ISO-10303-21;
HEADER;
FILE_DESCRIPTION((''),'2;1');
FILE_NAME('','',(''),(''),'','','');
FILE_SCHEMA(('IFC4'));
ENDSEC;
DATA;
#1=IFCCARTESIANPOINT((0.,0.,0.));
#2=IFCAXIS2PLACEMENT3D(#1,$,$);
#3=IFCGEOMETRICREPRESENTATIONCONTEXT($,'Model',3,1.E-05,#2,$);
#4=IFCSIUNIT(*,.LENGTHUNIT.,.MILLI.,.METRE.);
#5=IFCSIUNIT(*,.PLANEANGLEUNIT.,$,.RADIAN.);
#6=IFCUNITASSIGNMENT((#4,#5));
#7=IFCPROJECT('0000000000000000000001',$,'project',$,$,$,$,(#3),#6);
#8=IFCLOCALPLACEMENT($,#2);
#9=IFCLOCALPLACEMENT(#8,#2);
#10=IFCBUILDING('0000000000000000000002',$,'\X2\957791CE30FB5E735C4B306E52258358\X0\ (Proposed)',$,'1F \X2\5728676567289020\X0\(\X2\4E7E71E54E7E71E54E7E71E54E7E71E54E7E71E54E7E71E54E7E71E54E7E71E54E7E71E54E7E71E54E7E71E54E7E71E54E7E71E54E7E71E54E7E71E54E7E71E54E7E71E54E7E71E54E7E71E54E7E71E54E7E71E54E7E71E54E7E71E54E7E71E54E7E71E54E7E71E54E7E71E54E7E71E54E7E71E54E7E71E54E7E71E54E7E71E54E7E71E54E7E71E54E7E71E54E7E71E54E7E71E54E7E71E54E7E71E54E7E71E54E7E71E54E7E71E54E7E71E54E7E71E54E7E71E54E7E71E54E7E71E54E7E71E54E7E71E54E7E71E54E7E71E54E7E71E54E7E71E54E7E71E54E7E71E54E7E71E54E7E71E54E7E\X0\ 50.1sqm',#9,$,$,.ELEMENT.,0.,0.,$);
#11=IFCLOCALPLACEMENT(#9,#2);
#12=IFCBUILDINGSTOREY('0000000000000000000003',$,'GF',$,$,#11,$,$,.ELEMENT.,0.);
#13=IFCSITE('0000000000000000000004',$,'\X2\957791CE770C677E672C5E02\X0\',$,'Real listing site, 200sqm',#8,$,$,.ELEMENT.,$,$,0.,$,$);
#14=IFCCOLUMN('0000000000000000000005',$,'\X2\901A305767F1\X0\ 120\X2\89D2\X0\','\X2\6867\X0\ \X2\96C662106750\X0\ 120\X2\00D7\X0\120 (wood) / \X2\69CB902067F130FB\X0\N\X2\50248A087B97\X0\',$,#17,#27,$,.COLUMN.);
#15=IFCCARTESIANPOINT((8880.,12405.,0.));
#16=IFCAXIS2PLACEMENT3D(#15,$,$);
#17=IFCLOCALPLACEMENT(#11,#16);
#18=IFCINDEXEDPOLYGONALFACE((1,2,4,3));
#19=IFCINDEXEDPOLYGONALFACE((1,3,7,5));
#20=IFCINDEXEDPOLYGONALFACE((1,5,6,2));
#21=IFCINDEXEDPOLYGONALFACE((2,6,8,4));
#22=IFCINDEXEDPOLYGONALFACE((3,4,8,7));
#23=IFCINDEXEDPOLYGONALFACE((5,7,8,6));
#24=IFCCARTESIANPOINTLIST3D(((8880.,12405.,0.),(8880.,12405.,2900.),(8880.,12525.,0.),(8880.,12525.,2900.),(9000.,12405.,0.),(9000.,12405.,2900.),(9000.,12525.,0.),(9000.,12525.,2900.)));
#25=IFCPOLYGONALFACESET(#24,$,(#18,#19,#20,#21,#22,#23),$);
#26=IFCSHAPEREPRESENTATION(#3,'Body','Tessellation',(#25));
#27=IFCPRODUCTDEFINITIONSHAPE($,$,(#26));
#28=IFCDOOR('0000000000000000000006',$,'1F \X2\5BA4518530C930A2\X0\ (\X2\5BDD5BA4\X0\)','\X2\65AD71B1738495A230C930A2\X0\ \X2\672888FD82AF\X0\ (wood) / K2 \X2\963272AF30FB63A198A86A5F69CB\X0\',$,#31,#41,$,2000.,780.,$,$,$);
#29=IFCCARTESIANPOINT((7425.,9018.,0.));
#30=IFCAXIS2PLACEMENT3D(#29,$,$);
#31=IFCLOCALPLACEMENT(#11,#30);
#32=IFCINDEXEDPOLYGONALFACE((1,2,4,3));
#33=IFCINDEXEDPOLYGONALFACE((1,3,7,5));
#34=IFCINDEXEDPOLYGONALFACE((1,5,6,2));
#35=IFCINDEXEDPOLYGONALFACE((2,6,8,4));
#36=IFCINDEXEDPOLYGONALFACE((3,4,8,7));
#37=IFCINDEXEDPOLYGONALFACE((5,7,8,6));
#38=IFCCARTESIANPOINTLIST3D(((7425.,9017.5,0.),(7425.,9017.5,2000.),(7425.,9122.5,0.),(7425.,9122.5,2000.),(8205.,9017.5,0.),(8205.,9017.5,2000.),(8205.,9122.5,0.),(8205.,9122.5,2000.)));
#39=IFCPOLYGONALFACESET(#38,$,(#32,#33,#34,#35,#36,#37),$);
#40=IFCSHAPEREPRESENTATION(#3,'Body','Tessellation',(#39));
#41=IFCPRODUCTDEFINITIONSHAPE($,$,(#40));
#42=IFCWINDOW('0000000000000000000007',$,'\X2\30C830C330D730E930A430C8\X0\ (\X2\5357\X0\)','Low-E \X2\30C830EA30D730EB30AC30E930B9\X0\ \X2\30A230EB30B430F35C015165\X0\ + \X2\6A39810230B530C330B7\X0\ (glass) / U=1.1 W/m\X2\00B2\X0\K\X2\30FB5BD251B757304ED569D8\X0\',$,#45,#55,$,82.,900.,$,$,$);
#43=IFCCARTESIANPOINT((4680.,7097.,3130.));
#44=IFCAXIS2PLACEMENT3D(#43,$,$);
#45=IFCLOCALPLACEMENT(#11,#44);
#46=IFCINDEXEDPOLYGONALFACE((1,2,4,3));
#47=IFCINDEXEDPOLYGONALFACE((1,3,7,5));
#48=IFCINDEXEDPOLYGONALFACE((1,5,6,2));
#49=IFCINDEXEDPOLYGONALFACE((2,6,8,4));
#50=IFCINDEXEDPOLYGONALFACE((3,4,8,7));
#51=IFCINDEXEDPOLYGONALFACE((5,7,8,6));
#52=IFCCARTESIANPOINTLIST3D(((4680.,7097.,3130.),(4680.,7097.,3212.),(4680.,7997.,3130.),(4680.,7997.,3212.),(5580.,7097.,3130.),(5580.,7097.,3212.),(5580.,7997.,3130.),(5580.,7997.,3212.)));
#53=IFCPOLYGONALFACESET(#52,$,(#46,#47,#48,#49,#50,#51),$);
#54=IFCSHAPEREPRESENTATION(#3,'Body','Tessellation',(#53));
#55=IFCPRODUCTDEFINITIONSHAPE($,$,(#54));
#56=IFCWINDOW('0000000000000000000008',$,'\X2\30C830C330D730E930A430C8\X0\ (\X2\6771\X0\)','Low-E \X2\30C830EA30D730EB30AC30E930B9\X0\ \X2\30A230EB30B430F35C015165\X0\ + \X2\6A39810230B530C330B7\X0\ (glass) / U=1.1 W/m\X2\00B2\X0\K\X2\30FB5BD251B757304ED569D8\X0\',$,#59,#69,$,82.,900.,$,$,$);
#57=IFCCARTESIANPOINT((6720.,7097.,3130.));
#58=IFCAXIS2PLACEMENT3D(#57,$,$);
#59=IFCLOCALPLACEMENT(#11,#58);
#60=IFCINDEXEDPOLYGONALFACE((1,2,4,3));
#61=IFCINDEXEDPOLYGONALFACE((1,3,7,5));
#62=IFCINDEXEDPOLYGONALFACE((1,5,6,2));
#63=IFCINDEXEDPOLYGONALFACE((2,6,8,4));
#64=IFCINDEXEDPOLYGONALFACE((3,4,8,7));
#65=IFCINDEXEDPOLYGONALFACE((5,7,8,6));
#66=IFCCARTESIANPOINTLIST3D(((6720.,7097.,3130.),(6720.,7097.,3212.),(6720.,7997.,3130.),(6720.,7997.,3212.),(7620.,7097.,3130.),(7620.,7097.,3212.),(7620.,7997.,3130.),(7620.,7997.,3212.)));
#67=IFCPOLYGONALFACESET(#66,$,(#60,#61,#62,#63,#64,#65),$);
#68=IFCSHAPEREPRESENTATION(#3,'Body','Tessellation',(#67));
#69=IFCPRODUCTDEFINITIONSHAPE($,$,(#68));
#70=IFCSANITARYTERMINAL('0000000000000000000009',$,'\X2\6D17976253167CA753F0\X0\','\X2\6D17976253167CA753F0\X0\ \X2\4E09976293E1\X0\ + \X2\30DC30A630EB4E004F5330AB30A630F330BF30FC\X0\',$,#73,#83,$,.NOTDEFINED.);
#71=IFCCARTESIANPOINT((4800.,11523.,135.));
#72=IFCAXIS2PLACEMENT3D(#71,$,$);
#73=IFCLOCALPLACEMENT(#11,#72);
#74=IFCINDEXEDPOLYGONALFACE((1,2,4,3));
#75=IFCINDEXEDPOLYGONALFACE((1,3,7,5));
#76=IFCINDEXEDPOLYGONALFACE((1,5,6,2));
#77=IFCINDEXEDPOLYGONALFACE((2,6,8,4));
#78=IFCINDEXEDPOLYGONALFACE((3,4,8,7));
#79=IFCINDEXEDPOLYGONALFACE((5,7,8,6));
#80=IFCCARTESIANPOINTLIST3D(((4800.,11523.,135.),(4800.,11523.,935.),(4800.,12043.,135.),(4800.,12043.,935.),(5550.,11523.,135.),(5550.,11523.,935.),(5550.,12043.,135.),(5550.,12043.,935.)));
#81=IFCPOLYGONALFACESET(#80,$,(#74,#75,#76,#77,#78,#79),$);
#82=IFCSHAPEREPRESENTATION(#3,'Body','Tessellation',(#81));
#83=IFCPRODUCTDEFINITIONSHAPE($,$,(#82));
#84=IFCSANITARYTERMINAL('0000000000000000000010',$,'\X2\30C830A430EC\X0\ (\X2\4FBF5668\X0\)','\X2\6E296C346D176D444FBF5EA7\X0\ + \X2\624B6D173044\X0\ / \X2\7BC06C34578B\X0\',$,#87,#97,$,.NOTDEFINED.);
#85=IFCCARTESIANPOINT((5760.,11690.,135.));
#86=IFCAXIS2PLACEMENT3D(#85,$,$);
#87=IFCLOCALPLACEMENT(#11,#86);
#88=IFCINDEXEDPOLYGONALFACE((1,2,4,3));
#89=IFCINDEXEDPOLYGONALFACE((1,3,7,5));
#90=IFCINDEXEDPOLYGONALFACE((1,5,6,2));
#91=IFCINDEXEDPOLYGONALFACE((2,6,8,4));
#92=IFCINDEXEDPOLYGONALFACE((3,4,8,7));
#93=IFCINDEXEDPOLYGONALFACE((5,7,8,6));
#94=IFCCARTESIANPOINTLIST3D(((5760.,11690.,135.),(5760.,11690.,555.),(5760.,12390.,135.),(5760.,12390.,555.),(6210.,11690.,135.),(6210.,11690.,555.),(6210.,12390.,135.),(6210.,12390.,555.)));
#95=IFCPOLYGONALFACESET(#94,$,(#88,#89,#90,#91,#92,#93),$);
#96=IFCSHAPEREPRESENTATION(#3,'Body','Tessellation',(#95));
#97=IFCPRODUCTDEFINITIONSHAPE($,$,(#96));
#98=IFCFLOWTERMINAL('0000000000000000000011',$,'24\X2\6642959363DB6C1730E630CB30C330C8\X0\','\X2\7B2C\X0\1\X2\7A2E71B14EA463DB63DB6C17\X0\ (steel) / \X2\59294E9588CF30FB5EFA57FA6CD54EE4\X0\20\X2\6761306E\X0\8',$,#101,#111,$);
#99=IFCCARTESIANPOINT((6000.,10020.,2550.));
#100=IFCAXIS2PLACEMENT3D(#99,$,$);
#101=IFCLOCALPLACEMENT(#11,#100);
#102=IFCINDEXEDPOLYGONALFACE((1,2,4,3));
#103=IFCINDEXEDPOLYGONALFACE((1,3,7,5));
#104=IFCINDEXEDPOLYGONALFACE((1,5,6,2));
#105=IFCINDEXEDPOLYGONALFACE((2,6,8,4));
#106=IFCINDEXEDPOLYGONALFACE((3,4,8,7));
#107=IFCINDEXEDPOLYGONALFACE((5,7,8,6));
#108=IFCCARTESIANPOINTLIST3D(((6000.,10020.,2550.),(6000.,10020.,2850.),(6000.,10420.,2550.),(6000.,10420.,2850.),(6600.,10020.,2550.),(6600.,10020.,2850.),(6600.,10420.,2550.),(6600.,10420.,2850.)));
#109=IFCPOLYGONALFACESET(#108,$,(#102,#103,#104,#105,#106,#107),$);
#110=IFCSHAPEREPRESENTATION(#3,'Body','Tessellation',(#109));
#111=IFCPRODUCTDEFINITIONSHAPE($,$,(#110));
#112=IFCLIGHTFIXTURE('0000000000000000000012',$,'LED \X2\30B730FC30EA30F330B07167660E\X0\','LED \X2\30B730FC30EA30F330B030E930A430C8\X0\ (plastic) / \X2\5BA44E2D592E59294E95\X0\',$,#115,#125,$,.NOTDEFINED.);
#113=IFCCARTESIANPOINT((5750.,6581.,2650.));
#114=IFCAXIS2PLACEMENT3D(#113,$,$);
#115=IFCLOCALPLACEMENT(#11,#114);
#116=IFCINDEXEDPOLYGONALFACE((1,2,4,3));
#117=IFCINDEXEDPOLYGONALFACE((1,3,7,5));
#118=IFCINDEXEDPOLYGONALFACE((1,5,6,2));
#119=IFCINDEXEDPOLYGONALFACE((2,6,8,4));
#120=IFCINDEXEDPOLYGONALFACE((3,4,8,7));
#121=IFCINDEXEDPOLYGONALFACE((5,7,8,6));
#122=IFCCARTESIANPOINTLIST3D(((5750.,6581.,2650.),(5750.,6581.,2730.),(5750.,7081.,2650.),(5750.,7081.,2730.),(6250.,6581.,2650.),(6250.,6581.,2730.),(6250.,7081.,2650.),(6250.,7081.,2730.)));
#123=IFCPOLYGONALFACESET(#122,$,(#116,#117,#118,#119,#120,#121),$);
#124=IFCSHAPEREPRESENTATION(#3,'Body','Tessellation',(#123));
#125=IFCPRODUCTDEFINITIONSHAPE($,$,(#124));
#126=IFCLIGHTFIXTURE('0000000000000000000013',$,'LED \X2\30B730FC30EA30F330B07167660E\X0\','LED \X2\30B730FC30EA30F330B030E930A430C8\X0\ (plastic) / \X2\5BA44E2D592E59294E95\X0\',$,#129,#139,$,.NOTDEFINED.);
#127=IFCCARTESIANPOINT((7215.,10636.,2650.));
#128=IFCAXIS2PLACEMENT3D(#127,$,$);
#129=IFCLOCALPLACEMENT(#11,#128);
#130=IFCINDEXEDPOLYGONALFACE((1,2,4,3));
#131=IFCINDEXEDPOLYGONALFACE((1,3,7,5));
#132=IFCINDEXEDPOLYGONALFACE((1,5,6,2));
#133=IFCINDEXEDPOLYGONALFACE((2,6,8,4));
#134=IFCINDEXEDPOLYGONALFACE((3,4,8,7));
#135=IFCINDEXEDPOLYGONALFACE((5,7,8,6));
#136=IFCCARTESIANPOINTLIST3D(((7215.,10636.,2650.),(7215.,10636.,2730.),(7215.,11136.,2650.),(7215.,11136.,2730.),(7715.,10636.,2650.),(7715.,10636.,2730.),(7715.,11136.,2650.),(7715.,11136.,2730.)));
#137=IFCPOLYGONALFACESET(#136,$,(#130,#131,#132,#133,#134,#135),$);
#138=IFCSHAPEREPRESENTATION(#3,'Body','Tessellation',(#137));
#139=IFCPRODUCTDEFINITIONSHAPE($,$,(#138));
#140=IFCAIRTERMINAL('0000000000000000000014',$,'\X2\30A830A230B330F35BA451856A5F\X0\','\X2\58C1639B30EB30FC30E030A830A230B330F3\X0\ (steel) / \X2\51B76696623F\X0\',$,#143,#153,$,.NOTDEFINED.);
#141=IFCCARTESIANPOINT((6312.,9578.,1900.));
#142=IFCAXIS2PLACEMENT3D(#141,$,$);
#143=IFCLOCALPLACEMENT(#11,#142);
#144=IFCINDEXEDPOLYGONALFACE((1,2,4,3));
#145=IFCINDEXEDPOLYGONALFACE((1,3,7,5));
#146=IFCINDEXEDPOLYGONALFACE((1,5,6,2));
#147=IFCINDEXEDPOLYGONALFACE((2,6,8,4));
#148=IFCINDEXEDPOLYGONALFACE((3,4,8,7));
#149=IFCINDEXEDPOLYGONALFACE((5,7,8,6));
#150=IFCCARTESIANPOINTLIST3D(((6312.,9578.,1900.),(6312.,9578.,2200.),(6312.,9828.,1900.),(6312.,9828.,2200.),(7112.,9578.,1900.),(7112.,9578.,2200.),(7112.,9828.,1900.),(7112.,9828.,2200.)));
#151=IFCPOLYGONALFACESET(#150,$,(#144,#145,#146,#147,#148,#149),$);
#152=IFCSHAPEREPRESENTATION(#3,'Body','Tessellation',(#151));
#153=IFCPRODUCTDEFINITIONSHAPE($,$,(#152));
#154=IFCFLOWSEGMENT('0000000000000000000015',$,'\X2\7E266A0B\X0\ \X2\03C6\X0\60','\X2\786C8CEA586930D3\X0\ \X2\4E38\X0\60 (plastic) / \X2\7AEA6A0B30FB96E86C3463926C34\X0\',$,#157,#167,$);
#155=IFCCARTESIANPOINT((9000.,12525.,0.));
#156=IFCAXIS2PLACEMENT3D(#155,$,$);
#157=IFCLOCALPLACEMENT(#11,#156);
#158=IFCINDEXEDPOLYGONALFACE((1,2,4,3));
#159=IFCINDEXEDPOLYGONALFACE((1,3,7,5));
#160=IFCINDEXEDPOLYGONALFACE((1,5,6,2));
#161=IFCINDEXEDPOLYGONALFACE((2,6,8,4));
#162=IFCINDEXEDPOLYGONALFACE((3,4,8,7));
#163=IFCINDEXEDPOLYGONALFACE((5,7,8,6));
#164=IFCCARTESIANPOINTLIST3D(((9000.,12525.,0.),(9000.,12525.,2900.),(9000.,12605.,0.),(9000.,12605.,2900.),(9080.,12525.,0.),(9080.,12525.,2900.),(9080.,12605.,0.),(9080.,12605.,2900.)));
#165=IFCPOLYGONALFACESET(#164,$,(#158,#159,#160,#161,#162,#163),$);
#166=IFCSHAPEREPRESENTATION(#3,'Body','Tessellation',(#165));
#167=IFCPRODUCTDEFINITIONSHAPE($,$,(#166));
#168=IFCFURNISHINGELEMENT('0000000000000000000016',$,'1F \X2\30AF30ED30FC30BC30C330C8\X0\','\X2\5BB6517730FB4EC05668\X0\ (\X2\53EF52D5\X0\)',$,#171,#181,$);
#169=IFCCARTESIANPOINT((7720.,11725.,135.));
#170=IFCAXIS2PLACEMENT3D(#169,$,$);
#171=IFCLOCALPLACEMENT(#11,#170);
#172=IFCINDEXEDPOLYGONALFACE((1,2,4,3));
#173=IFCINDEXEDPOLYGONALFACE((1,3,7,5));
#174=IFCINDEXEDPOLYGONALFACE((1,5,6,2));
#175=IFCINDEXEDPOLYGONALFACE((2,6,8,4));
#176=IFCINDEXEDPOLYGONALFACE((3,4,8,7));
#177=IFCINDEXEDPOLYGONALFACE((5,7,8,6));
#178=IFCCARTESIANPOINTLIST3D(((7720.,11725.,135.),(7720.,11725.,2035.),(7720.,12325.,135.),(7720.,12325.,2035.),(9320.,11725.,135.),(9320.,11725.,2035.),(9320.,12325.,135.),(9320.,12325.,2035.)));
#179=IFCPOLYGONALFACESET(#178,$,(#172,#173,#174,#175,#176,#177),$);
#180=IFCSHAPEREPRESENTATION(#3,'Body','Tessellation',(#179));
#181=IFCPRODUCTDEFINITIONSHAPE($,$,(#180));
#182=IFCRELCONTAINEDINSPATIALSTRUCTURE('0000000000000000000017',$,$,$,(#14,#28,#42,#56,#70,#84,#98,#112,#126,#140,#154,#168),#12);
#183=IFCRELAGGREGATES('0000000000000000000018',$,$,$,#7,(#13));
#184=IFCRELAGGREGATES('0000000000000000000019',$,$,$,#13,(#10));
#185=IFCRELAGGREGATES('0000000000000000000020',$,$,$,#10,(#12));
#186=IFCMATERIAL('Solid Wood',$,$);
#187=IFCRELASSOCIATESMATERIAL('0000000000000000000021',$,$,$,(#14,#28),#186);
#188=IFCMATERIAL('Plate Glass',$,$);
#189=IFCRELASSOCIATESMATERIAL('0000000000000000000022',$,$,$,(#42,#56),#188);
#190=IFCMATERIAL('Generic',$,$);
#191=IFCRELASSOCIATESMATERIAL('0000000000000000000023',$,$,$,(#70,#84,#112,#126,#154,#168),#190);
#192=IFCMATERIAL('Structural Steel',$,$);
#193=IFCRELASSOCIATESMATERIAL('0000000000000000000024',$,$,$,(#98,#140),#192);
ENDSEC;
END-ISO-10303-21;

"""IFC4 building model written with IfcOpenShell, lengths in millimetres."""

from ifc_helpers import new_model, si_unit, frame, frame_2d, origin, place, context, project, spatial, rectangle, extrude, material, element, save


model = new_model("IFC4")

# Units and contexts
model_context = context("Model", 3, precision=1e-05, world=origin())
ifc_project = project(units=[si_unit("LENGTHUNIT", "METRE", prefix="MILLI"), si_unit("PLANEANGLEUNIT", "RADIAN")], contexts=[model_context])

# Site, building, storey
site_placement = place(None, origin())
site = spatial("IfcSite", under=ifc_project, at=site_placement, Name="長野県松本市", ObjectType="Real listing site, 200sqm", CompositionType="ELEMENT", RefElevation=0.0)
building_placement = place(site_placement, origin())
building = spatial("IfcBuilding", under=site, at=building_placement, Name="長野・平屋の別荘 (Proposed)", ObjectType="1F 在来木造(乾燥乾燥乾燥乾燥乾燥乾燥乾燥乾燥乾燥乾燥乾燥乾燥乾燥乾燥乾燥乾燥乾燥乾燥乾燥乾燥乾燥乾燥乾燥乾燥乾燥乾燥乾燥乾燥乾燥乾燥乾燥乾燥乾燥乾燥乾燥乾燥乾燥乾燥乾燥乾燥乾燥乾燥乾燥乾燥乾燥乾燥乾燥乾燥乾燥乾燥乾燥乾燥乾燥乾燥乾燥乾燥乾燥乾 50.1sqm", CompositionType="ELEMENT", ElevationOfRefHeight=0.0, ElevationOfTerrain=0.0)
storey_placement = place(building_placement, origin())
storey = spatial("IfcBuildingStorey", under=building, at=storey_placement, Name="GF", CompositionType="ELEMENT", Elevation=0.0)

# Column
ifc_material_1 = material(Name="Solid Wood")
column_1_placement = place(storey_placement, frame((8880.0, 12405.0, 0.0)))
element("IfcColumn", 1, at=column_1_placement, inside=storey, material=ifc_material_1, Name="通し柱 120角", Description="桧 集成材 120×120 (wood) / 構造柱・N値計算", PredefinedType="COLUMN", context=model_context, shape_type="SweptSolid", body=[
    extrude(rectangle(XDim=120.0, YDim=120.0, at=frame_2d((60.0, 60.0))), frame((8880.0, 12405.0, 0.0)), (0.0, 0.0, 1.0), 2900.0),
])

# Door
door_placement = place(storey_placement, frame((7425.0, 9018.0, 0.0)))
element("IfcDoor", 2, at=door_placement, inside=storey, material=ifc_material_1, Name="1F 室内ドア (寝室)", Description="断熱玄関ドア 木製芯 (wood) / K2 防犯・採風機構", OverallHeight=2000.0, OverallWidth=780.0, context=model_context, shape_type="SweptSolid", body=[
    extrude(rectangle(XDim=780.0, YDim=105.0, at=frame_2d((390.0, 52.0))), frame((7425.0, 9018.0, 0.0)), (0.0, 0.0, 1.0), 2000.0),
])

# Windows
ifc_material_2 = material(Name="Plate Glass")
window_1_placement = place(storey_placement, frame((4680.0, 7097.0, 3130.0)))
element("IfcWindow", 3, at=window_1_placement, inside=storey, material=ifc_material_2, Name="トップライト (南)", Description="Low-E トリプルガラス アルゴン封入 + 樹脂サッシ (glass) / U=1.1 W/m²K・寒冷地仕様", OverallHeight=82.0, OverallWidth=900.0, context=model_context, shape_type="SweptSolid", body=[
    extrude(rectangle(XDim=900.0, YDim=900.0, at=frame_2d((450.0, 450.0))), frame((4680.0, 7097.0, 3130.0)), (0.0, 0.0, 1.0), 82.0),
])
window_2_placement = place(storey_placement, frame((6720.0, 7097.0, 3130.0)))
element("IfcWindow", 4, at=window_2_placement, inside=storey, material=ifc_material_2, Name="トップライト (東)", Description="Low-E トリプルガラス アルゴン封入 + 樹脂サッシ (glass) / U=1.1 W/m²K・寒冷地仕様", OverallHeight=82.0, OverallWidth=900.0, context=model_context, shape_type="SweptSolid", body=[
    extrude(rectangle(XDim=900.0, YDim=900.0, at=frame_2d((450.0, 450.0))), frame((6720.0, 7097.0, 3130.0)), (0.0, 0.0, 1.0), 82.0),
])

# Sanitary terminals
ifc_material_3 = material(Name="Generic")
sanitary_terminal_1_placement = place(storey_placement, frame((4800.0, 11523.0, 135.0)))
element("IfcSanitaryTerminal", 5, at=sanitary_terminal_1_placement, inside=storey, material=ifc_material_3, Name="洗面化粧台", Description="洗面化粧台 三面鏡 + ボウル一体カウンター", PredefinedType="NOTDEFINED", context=model_context, shape_type="SweptSolid", body=[
    extrude(rectangle(XDim=750.0, YDim=520.0, at=frame_2d((375.0, 260.0))), frame((4800.0, 11523.0, 135.0)), (0.0, 0.0, 1.0), 800.0),
])
sanitary_terminal_2_placement = place(storey_placement, frame((5760.0, 11690.0, 135.0)))
element("IfcSanitaryTerminal", 6, at=sanitary_terminal_2_placement, inside=storey, material=ifc_material_3, Name="トイレ (便器)", Description="温水洗浄便座 + 手洗い / 節水型", PredefinedType="NOTDEFINED", context=model_context, shape_type="SweptSolid", body=[
    extrude(rectangle(XDim=450.0, YDim=700.0, at=frame_2d((225.0, 350.0))), frame((5760.0, 11690.0, 135.0)), (0.0, 0.0, 1.0), 420.0),
])

# Flow terminal
ifc_material_4 = material(Name="Structural Steel")
flow_terminal_placement = place(storey_placement, frame((6000.0, 10020.0, 2550.0)))
element("IfcFlowTerminal", 7, at=flow_terminal_placement, inside=storey, material=ifc_material_4, Name="24時間換気ユニット", Description="第1種熱交換換気 (steel) / 天井裏・建基法令20条の8", context=model_context, shape_type="SweptSolid", body=[
    extrude(rectangle(XDim=600.0, YDim=400.0, at=frame_2d((300.0, 200.0))), frame((6000.0, 10020.0, 2550.0)), (0.0, 0.0, 1.0), 300.0),
])

# Light fixtures
light_fixture_1_placement = place(storey_placement, frame((5750.0, 6581.0, 2650.0)))
element("IfcLightFixture", 8, at=light_fixture_1_placement, inside=storey, material=ifc_material_3, Name="LED シーリング照明", Description="LED シーリングライト (plastic) / 室中央天井", PredefinedType="NOTDEFINED", context=model_context, shape_type="SweptSolid", body=[
    extrude(rectangle(XDim=500.0, YDim=500.0, at=frame_2d((250.0, 250.0))), frame((5750.0, 6581.0, 2650.0)), (0.0, 0.0, 1.0), 80.0),
])
light_fixture_2_placement = place(storey_placement, frame((7215.0, 10636.0, 2650.0)))
element("IfcLightFixture", 9, at=light_fixture_2_placement, inside=storey, material=ifc_material_3, Name="LED シーリング照明", Description="LED シーリングライト (plastic) / 室中央天井", PredefinedType="NOTDEFINED", context=model_context, shape_type="SweptSolid", body=[
    extrude(rectangle(XDim=500.0, YDim=500.0, at=frame_2d((250.0, 250.0))), frame((7215.0, 10636.0, 2650.0)), (0.0, 0.0, 1.0), 80.0),
])

# Air terminal
air_terminal_placement = place(storey_placement, frame((6312.0, 9578.0, 1900.0)))
element("IfcAirTerminal", 10, at=air_terminal_placement, inside=storey, material=ifc_material_4, Name="エアコン室内機", Description="壁掛ルームエアコン (steel) / 冷暖房", PredefinedType="NOTDEFINED", context=model_context, shape_type="SweptSolid", body=[
    extrude(rectangle(XDim=800.0, YDim=250.0, at=frame_2d((400.0, 125.0))), frame((6312.0, 9578.0, 1900.0)), (0.0, 0.0, 1.0), 300.0),
])

# Flow segment
flow_segment_placement = place(storey_placement, frame((9000.0, 12525.0, 0.0)))
element("IfcFlowSegment", 11, at=flow_segment_placement, inside=storey, material=ifc_material_3, Name="縦樋 φ60", Description="硬質塩ビ 丸60 (plastic) / 竪樋・雨水排水", context=model_context, shape_type="SweptSolid", body=[
    extrude(rectangle(XDim=80.0, YDim=80.0, at=frame_2d((40.0, 40.0))), frame((9000.0, 12525.0, 0.0)), (0.0, 0.0, 1.0), 2900.0),
])

# Furnishing element
furnishing_placement = place(storey_placement, frame((7720.0, 11725.0, 135.0)))
element("IfcFurnishingElement", 12, at=furnishing_placement, inside=storey, material=ifc_material_3, Name="1F クローゼット", Description="家具・什器 (可動)", context=model_context, shape_type="SweptSolid", body=[
    extrude(rectangle(XDim=1600.0, YDim=600.0, at=frame_2d((800.0, 300.0))), frame((7720.0, 11725.0, 135.0)), (0.0, 0.0, 1.0), 1900.0),
])

save(model, "model.ifc")
